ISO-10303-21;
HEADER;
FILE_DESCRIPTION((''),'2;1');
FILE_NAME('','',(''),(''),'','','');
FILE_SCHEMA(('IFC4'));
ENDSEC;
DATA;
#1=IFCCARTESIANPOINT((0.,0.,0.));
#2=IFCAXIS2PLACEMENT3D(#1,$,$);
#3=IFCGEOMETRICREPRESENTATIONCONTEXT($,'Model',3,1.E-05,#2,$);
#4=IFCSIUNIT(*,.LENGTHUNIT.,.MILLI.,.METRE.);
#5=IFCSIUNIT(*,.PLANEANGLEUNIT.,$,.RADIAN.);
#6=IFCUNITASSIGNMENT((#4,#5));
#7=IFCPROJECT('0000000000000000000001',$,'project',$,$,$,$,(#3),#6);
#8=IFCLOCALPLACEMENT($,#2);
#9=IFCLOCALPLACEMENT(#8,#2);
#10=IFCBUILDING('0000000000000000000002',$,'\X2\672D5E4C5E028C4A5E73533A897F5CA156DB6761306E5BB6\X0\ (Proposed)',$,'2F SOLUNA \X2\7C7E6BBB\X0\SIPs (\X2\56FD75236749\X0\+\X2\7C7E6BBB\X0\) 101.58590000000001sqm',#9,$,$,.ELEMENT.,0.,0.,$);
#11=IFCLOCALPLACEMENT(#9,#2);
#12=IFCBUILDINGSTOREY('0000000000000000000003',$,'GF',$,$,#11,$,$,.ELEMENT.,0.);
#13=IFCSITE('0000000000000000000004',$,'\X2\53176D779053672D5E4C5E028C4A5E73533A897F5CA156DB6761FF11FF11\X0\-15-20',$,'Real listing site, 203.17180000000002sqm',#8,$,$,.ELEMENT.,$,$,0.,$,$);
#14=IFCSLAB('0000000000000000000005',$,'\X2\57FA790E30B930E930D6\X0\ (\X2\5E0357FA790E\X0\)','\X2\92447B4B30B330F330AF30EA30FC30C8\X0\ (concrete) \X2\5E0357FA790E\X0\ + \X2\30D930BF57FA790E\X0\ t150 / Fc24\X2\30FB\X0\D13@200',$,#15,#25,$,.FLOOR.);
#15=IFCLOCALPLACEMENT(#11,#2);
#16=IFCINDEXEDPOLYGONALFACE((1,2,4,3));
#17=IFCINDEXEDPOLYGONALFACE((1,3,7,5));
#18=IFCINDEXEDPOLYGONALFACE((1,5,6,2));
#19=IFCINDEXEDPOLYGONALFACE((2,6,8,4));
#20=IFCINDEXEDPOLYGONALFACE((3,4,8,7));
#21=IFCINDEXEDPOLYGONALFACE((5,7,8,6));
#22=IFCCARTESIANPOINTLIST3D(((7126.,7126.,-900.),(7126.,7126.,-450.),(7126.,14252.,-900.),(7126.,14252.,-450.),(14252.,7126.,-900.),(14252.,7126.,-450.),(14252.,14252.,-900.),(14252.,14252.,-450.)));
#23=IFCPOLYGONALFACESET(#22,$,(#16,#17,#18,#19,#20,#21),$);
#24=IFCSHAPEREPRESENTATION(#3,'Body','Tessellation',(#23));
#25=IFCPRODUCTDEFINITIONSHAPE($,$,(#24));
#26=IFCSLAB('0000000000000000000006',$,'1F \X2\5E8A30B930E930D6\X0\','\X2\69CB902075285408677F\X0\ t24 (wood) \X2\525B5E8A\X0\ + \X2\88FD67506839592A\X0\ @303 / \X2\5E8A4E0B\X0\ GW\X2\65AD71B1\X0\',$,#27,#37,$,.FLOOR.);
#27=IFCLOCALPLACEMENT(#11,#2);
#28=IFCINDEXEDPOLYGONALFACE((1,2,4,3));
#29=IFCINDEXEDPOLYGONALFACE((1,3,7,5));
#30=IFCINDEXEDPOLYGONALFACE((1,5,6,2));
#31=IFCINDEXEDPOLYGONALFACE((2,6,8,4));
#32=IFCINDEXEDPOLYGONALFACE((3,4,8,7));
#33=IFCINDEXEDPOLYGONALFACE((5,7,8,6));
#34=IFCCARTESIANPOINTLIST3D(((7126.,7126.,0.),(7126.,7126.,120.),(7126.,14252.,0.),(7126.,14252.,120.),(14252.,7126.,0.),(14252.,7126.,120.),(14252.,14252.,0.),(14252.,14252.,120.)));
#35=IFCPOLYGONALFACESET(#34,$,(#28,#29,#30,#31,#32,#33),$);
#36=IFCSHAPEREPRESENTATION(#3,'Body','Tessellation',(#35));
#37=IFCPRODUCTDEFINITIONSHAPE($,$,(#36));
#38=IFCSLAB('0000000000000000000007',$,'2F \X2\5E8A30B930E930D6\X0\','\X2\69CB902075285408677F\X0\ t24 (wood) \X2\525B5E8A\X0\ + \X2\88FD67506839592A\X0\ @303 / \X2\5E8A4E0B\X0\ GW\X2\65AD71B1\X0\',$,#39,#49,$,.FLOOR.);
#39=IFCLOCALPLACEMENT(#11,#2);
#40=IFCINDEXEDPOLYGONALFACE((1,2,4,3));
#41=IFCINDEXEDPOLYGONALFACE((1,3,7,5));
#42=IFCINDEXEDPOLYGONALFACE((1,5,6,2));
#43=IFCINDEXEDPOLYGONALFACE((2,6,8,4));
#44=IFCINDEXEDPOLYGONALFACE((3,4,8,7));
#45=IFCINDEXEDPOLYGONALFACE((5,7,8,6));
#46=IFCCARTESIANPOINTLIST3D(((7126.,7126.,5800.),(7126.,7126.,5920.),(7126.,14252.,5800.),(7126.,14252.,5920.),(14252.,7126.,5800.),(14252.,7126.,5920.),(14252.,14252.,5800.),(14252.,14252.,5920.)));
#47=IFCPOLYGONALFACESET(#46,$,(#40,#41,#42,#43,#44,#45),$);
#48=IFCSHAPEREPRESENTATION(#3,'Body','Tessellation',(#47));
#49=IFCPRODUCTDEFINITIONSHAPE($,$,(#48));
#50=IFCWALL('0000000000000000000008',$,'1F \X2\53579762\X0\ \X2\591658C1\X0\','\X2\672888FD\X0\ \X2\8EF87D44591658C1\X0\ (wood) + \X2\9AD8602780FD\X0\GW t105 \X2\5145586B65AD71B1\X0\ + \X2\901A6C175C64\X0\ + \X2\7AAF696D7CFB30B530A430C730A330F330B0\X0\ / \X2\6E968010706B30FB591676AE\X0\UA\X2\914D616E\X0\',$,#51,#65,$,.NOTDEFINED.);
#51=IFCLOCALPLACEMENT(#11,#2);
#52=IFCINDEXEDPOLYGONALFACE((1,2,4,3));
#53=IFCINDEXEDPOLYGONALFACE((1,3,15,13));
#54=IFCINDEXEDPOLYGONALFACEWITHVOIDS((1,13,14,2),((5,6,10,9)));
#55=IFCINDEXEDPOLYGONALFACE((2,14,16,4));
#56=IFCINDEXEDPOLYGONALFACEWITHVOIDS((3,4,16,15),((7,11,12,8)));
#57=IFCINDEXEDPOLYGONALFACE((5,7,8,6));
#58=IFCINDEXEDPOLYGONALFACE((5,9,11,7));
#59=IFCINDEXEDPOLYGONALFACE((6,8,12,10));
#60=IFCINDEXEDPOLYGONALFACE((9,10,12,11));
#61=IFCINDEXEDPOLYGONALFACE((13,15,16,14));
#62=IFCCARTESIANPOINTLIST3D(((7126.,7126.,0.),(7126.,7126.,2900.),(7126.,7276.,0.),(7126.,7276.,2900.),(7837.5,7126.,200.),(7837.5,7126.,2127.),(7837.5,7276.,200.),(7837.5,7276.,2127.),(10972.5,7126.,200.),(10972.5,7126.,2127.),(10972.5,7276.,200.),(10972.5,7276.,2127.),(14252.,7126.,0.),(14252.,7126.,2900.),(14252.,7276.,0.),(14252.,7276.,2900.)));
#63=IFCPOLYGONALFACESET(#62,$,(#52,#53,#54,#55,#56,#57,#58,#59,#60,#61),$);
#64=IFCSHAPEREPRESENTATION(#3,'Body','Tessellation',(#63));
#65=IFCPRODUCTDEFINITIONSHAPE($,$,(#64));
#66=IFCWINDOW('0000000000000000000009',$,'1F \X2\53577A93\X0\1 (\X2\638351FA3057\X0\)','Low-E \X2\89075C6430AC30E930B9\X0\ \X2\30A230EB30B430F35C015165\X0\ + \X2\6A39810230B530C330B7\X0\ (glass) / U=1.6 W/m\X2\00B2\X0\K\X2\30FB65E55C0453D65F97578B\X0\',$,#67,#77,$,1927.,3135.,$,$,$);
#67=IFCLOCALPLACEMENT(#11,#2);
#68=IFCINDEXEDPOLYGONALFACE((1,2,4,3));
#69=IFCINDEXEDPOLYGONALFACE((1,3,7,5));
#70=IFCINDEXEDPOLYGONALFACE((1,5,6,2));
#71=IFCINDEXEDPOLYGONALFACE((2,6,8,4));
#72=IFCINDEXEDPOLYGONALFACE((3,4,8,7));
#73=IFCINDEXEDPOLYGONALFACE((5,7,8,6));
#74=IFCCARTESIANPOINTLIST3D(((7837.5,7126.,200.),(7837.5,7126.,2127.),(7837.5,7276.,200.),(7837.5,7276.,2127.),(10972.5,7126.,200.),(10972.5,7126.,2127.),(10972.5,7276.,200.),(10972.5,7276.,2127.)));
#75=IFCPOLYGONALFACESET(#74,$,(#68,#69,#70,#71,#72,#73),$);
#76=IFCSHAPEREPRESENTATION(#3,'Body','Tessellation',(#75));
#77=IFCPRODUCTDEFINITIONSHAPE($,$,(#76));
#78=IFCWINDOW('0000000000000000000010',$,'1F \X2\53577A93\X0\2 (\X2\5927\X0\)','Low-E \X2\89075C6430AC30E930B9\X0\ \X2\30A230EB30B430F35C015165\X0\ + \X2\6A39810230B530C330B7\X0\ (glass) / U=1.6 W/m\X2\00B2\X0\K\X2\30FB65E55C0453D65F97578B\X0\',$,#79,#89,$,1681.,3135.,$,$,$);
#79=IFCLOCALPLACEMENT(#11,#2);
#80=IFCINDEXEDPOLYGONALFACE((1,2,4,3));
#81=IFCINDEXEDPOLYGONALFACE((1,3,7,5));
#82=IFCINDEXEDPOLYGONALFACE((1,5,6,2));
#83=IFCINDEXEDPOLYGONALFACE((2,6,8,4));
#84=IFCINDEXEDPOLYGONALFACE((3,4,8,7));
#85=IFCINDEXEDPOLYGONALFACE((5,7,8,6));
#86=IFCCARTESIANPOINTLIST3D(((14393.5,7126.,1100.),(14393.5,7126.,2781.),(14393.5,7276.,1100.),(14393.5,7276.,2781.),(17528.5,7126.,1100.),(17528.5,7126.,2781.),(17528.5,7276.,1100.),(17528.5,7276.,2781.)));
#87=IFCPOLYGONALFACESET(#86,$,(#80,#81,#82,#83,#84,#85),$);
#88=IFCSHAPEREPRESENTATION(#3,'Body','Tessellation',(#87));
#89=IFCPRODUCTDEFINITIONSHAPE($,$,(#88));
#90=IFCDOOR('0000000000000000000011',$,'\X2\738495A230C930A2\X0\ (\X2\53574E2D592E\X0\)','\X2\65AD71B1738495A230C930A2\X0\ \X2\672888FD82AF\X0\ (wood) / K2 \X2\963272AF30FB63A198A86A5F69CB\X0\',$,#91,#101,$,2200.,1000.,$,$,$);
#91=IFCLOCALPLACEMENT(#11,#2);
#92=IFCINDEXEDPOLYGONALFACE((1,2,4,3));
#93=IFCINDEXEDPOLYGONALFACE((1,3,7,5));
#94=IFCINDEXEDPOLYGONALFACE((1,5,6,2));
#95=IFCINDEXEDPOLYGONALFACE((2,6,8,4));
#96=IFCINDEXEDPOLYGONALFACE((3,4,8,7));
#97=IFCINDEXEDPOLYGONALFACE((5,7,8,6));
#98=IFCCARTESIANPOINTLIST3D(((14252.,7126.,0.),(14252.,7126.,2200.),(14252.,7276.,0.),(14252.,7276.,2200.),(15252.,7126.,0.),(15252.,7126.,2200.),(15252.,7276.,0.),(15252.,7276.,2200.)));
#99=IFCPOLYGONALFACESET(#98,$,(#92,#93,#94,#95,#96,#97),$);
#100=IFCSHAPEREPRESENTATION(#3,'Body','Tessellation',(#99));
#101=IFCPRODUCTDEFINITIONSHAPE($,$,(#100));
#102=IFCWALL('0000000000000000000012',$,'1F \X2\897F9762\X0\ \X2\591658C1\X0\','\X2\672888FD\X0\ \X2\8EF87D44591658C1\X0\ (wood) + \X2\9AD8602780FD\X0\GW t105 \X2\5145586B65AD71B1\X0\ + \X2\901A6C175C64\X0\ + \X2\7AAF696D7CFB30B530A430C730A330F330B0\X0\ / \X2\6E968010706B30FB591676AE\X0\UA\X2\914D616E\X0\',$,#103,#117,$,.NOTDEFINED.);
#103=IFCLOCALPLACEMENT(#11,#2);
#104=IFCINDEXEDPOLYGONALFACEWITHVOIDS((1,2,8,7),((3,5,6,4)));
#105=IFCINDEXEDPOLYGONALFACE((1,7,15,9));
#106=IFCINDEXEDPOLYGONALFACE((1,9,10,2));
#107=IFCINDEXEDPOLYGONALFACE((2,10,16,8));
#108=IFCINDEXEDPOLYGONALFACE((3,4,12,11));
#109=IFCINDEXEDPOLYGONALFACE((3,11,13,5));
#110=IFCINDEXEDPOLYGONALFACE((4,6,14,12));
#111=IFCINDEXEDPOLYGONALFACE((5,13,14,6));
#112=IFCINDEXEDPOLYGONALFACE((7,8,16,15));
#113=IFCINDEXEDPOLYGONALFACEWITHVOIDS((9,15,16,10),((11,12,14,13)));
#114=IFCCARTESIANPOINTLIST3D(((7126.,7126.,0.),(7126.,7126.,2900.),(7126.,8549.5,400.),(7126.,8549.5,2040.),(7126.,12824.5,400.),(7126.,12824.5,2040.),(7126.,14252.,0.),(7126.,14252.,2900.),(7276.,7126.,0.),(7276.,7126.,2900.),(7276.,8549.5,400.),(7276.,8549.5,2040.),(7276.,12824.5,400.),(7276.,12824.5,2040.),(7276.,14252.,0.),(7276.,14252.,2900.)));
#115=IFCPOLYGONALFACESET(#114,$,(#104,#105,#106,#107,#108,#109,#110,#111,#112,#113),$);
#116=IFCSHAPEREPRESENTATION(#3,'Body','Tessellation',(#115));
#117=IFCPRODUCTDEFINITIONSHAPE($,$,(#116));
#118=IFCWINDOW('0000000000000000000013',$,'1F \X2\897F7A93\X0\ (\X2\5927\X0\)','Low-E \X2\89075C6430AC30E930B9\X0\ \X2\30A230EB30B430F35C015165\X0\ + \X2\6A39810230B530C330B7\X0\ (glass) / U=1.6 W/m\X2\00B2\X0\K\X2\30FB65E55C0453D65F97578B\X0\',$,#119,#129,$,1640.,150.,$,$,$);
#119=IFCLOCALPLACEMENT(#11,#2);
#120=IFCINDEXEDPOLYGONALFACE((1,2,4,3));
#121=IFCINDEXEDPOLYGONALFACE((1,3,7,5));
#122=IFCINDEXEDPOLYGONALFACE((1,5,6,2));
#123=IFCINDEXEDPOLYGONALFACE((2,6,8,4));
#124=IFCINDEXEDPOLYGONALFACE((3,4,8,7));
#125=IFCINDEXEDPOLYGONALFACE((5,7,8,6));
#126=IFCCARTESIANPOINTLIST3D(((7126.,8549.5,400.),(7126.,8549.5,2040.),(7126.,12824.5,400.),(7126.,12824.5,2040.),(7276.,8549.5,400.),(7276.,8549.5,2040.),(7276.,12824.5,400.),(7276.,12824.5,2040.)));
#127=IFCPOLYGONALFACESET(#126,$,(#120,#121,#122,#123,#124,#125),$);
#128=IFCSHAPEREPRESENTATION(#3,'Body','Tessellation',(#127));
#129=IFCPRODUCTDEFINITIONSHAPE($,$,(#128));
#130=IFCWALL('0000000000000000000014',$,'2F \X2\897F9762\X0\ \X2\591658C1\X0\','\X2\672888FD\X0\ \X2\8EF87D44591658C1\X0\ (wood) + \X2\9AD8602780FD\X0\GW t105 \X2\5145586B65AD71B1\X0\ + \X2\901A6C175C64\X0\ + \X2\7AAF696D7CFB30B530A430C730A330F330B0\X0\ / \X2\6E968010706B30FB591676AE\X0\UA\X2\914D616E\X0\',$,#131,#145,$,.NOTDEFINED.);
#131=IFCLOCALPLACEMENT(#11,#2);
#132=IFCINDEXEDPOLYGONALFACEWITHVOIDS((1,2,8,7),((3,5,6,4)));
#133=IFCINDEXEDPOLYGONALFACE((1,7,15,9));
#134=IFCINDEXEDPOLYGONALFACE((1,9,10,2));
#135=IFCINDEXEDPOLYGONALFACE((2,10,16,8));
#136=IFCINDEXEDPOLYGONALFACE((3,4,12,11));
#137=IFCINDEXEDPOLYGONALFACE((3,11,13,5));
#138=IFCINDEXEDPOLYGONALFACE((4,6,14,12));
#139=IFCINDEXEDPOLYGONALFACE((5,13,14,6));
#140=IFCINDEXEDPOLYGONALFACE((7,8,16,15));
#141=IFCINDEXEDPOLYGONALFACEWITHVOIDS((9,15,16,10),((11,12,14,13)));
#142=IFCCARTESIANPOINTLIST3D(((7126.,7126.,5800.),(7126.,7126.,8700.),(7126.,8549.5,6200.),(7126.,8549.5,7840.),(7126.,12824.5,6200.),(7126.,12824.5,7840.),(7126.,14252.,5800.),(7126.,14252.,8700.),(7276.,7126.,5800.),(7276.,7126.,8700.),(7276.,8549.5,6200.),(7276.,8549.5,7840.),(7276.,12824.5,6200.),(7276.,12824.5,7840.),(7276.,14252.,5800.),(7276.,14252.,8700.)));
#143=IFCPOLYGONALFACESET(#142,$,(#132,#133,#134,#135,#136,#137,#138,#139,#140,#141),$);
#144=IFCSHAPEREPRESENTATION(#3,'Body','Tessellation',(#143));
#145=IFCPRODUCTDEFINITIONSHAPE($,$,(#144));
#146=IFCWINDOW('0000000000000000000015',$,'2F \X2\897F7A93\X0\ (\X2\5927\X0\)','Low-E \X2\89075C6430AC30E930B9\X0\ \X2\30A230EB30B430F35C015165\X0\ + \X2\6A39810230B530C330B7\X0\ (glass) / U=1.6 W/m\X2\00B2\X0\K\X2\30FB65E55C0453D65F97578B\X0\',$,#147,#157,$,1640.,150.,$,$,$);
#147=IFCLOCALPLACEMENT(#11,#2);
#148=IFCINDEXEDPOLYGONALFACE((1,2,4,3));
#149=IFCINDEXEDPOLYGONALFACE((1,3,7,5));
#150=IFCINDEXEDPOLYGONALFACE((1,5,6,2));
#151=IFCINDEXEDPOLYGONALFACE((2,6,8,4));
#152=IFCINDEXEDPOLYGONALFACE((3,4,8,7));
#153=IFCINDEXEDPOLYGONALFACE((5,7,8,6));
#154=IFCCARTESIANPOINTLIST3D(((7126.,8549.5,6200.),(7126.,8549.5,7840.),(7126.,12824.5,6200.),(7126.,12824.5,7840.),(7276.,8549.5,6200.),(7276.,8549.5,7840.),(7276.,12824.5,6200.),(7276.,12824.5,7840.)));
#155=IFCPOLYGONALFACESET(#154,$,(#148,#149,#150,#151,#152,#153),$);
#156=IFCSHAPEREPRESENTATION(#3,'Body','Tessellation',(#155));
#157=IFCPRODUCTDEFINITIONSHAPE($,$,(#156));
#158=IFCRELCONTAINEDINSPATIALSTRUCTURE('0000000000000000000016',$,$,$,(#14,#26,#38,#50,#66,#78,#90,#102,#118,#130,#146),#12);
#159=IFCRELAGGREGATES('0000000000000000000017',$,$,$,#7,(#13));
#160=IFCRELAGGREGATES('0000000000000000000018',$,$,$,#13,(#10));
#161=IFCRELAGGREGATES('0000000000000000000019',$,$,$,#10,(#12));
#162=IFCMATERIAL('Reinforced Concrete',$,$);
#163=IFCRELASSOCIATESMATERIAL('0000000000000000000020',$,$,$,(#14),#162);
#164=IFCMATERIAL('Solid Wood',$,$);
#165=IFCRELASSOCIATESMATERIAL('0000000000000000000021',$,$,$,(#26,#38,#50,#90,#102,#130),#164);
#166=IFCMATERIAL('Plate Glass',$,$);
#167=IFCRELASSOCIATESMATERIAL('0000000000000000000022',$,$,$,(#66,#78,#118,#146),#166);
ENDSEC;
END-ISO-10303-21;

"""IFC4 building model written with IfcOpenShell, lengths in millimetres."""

from ifc_helpers import new_model, si_unit, frame, frame_2d, origin, place, context, project, spatial, rectangle, extrude, material, element, fill, save


model = new_model("IFC4")

# Units and contexts
model_context = context("Model", 3, precision=1e-05, world=origin())
ifc_project = project(units=[si_unit("LENGTHUNIT", "METRE", prefix="MILLI"), si_unit("PLANEANGLEUNIT", "RADIAN")], contexts=[model_context])

# Site, building, storey
site_placement = place(None, origin())
site = spatial("IfcSite", under=ifc_project, at=site_placement, Name="北海道札幌市豊平区西岡四条１１-15-20", ObjectType="Real listing site, 203.17180000000002sqm", CompositionType="ELEMENT", RefElevation=0.0)
building_placement = place(site_placement, origin())
building = spatial("IfcBuilding", under=site, at=building_placement, Name="札幌市豊平区西岡四条の家 (Proposed)", ObjectType="2F SOLUNA 籾殻SIPs (国産杉+籾殻) 101.58590000000001sqm", CompositionType="ELEMENT", ElevationOfRefHeight=0.0, ElevationOfTerrain=0.0)
storey_placement = place(building_placement, origin())
storey = spatial("IfcBuildingStorey", under=building, at=storey_placement, Name="GF", CompositionType="ELEMENT", Elevation=0.0)

# Slabs
ifc_material_1 = material(Name="Reinforced Concrete")
slab_1_placement = place(storey_placement, frame((3563.0, 3563.0, -450.0)))
element("IfcSlab", 1, at=slab_1_placement, inside=storey, material=ifc_material_1, Name="基礎スラブ (布基礎)", Description="鉄筋コンクリート (concrete) 布基礎 + ベタ基礎 t150 / Fc24・D13@200", PredefinedType="FLOOR", context=model_context, shape_type="SweptSolid", body=[
    extrude(rectangle(XDim=7126.0, YDim=7126.0, at=frame_2d((3563.0, 3563.0))), frame((3563.0, 3563.0, -450.0)), (0.0, 0.0, 1.0), 450.0),
])
ifc_material_2 = material(Name="Solid Wood")
slab_2_placement = place(storey_placement, frame((3563.0, 3563.0, 0.0)))
element("IfcSlab", 2, at=slab_2_placement, inside=storey, material=ifc_material_2, Name="1F 床スラブ", Description="構造用合板 t24 (wood) 剛床 + 製材根太 @303 / 床下 GW断熱", PredefinedType="FLOOR", context=model_context, shape_type="SweptSolid", body=[
    extrude(rectangle(XDim=7126.0, YDim=7126.0, at=frame_2d((3563.0, 3563.0))), frame((3563.0, 3563.0, 0.0)), (0.0, 0.0, 1.0), 120.0),
])
slab_3_placement = place(storey_placement, frame((3563.0, 3563.0, 2900.0)))
element("IfcSlab", 3, at=slab_3_placement, inside=storey, material=ifc_material_2, Name="2F 床スラブ", Description="構造用合板 t24 (wood) 剛床 + 製材根太 @303 / 床下 GW断熱", PredefinedType="FLOOR", context=model_context, shape_type="SweptSolid", body=[
    extrude(rectangle(XDim=7126.0, YDim=7126.0, at=frame_2d((3563.0, 3563.0))), frame((3563.0, 3563.0, 2900.0)), (0.0, 0.0, 1.0), 120.0),
])

# Wall, openings, windows, door
wall_1_placement = place(storey_placement, frame((3563.0, 3563.0, 0.0)))
wall_1 = element("IfcWall", 4, at=wall_1_placement, inside=storey, material=ifc_material_2, Name="1F 南面 外壁", Description="木製 軸組外壁 (wood) + 高性能GW t105 充填断熱 + 通気層 + 窯業系サイディング / 準耐火・外皮UA配慮", PredefinedType="NOTDEFINED", context=model_context, shape_type="SweptSolid", body=[
    extrude(rectangle(XDim=7126.0, YDim=150.0, at=frame_2d((3563.0, 75.0))), frame((3563.0, 3563.0, 0.0)), (0.0, 0.0, 1.0), 2900.0),
])
opening_1_placement = place(storey_placement, frame((3919.0, 3563.0, 100.0)))
opening_1 = element("IfcOpeningElement", 5, at=opening_1_placement, cuts=wall_1, PredefinedType="NOTDEFINED", context=model_context, shape_type="SweptSolid", body=[
    extrude(rectangle(XDim=3135.0, YDim=150.0, at=frame_2d((1567.0, 75.0))), frame((3919.0, 3563.0, 100.0)), (0.0, 0.0, 1.0), 1927.0),
])
opening_2_placement = place(storey_placement, frame((7197.0, 3563.0, 550.0)))
opening_2 = element("IfcOpeningElement", 6, at=opening_2_placement, cuts=wall_1, PredefinedType="NOTDEFINED", context=model_context, shape_type="SweptSolid", body=[
    extrude(rectangle(XDim=3135.0, YDim=150.0, at=frame_2d((1567.0, 75.0))), frame((7197.0, 3563.0, 550.0)), (0.0, 0.0, 1.0), 1681.0),
])
opening_3_placement = place(storey_placement, frame((7126.0, 3563.0, 0.0)))
opening_3 = element("IfcOpeningElement", 7, at=opening_3_placement, cuts=wall_1, PredefinedType="NOTDEFINED", context=model_context, shape_type="SweptSolid", body=[
    extrude(rectangle(XDim=1000.0, YDim=150.0, at=frame_2d((500.0, 75.0))), frame((7126.0, 3563.0, 0.0)), (0.0, 0.0, 1.0), 2200.0),
])
ifc_material_3 = material(Name="Plate Glass")
window_1_placement = place(storey_placement, frame((3919.0, 3563.0, 100.0)))
window_1 = element("IfcWindow", 8, at=window_1_placement, inside=storey, material=ifc_material_3, Name="1F 南窓1 (掃出し)", Description="Low-E 複層ガラス アルゴン封入 + 樹脂サッシ (glass) / U=1.6 W/m²K・日射取得型", OverallHeight=1927.0, OverallWidth=3135.0, context=model_context, shape_type="SweptSolid", body=[
    extrude(rectangle(XDim=3135.0, YDim=150.0, at=frame_2d((1567.0, 75.0))), frame((3919.0, 3563.0, 100.0)), (0.0, 0.0, 1.0), 1927.0),
])
fill(opening_1, window_1)
window_2_placement = place(storey_placement, frame((7197.0, 3563.0, 550.0)))
window_2 = element("IfcWindow", 9, at=window_2_placement, inside=storey, material=ifc_material_3, Name="1F 南窓2 (大)", Description="Low-E 複層ガラス アルゴン封入 + 樹脂サッシ (glass) / U=1.6 W/m²K・日射取得型", OverallHeight=1681.0, OverallWidth=3135.0, context=model_context, shape_type="SweptSolid", body=[
    extrude(rectangle(XDim=3135.0, YDim=150.0, at=frame_2d((1567.0, 75.0))), frame((7197.0, 3563.0, 550.0)), (0.0, 0.0, 1.0), 1681.0),
])
fill(opening_2, window_2)
door_placement = place(storey_placement, frame((7126.0, 3563.0, 0.0)))
door = element("IfcDoor", 10, at=door_placement, inside=storey, material=ifc_material_2, Name="玄関ドア (南中央)", Description="断熱玄関ドア 木製芯 (wood) / K2 防犯・採風機構", OverallHeight=2200.0, OverallWidth=1000.0, context=model_context, shape_type="SweptSolid", body=[
    extrude(rectangle(XDim=1000.0, YDim=150.0, at=frame_2d((500.0, 75.0))), frame((7126.0, 3563.0, 0.0)), (0.0, 0.0, 1.0), 2200.0),
])
fill(opening_3, door)

# Wall, opening, window
wall_2_placement = place(storey_placement, frame((3563.0, 3563.0, 0.0)))
wall_2 = element("IfcWall", 11, at=wall_2_placement, inside=storey, material=ifc_material_2, Name="1F 西面 外壁", Description="木製 軸組外壁 (wood) + 高性能GW t105 充填断熱 + 通気層 + 窯業系サイディング / 準耐火・外皮UA配慮", PredefinedType="NOTDEFINED", context=model_context, shape_type="SweptSolid", body=[
    extrude(rectangle(XDim=150.0, YDim=7126.0, at=frame_2d((75.0, 3563.0))), frame((3563.0, 3563.0, 0.0)), (0.0, 0.0, 1.0), 2900.0),
])
opening_4_placement = place(storey_placement, frame((3563.0, 4275.0, 200.0)))
opening_4 = element("IfcOpeningElement", 12, at=opening_4_placement, cuts=wall_2, PredefinedType="NOTDEFINED", context=model_context, shape_type="SweptSolid", body=[
    extrude(rectangle(XDim=150.0, YDim=4275.0, at=frame_2d((75.0, 2137.0))), frame((3563.0, 4275.0, 200.0)), (0.0, 0.0, 1.0), 1640.0),
])
window_3_placement = place(storey_placement, frame((3563.0, 4275.0, 200.0)))
window_3 = element("IfcWindow", 13, at=window_3_placement, inside=storey, material=ifc_material_3, Name="1F 西窓 (大)", Description="Low-E 複層ガラス アルゴン封入 + 樹脂サッシ (glass) / U=1.6 W/m²K・日射取得型", OverallHeight=1640.0, OverallWidth=150.0, context=model_context, shape_type="SweptSolid", body=[
    extrude(rectangle(XDim=150.0, YDim=4275.0, at=frame_2d((75.0, 2137.0))), frame((3563.0, 4275.0, 200.0)), (0.0, 0.0, 1.0), 1640.0),
])
fill(opening_4, window_3)

# Wall, opening, window
wall_3_placement = place(storey_placement, frame((3563.0, 3563.0, 2900.0)))
wall_3 = element("IfcWall", 14, at=wall_3_placement, inside=storey, material=ifc_material_2, Name="2F 西面 外壁", Description="木製 軸組外壁 (wood) + 高性能GW t105 充填断熱 + 通気層 + 窯業系サイディング / 準耐火・外皮UA配慮", PredefinedType="NOTDEFINED", context=model_context, shape_type="SweptSolid", body=[
    extrude(rectangle(XDim=150.0, YDim=7126.0, at=frame_2d((75.0, 3563.0))), frame((3563.0, 3563.0, 2900.0)), (0.0, 0.0, 1.0), 2900.0),
])
opening_5_placement = place(storey_placement, frame((3563.0, 4275.0, 3100.0)))
opening_5 = element("IfcOpeningElement", 15, at=opening_5_placement, cuts=wall_3, PredefinedType="NOTDEFINED", context=model_context, shape_type="SweptSolid", body=[
    extrude(rectangle(XDim=150.0, YDim=4275.0, at=frame_2d((75.0, 2137.0))), frame((3563.0, 4275.0, 3100.0)), (0.0, 0.0, 1.0), 1640.0),
])
window_4_placement = place(storey_placement, frame((3563.0, 4275.0, 3100.0)))
window_4 = element("IfcWindow", 16, at=window_4_placement, inside=storey, material=ifc_material_3, Name="2F 西窓 (大)", Description="Low-E 複層ガラス アルゴン封入 + 樹脂サッシ (glass) / U=1.6 W/m²K・日射取得型", OverallHeight=1640.0, OverallWidth=150.0, context=model_context, shape_type="SweptSolid", body=[
    extrude(rectangle(XDim=150.0, YDim=4275.0, at=frame_2d((75.0, 2137.0))), frame((3563.0, 4275.0, 3100.0)), (0.0, 0.0, 1.0), 1640.0),
])
fill(opening_5, window_4)

save(model, "model.ifc")
